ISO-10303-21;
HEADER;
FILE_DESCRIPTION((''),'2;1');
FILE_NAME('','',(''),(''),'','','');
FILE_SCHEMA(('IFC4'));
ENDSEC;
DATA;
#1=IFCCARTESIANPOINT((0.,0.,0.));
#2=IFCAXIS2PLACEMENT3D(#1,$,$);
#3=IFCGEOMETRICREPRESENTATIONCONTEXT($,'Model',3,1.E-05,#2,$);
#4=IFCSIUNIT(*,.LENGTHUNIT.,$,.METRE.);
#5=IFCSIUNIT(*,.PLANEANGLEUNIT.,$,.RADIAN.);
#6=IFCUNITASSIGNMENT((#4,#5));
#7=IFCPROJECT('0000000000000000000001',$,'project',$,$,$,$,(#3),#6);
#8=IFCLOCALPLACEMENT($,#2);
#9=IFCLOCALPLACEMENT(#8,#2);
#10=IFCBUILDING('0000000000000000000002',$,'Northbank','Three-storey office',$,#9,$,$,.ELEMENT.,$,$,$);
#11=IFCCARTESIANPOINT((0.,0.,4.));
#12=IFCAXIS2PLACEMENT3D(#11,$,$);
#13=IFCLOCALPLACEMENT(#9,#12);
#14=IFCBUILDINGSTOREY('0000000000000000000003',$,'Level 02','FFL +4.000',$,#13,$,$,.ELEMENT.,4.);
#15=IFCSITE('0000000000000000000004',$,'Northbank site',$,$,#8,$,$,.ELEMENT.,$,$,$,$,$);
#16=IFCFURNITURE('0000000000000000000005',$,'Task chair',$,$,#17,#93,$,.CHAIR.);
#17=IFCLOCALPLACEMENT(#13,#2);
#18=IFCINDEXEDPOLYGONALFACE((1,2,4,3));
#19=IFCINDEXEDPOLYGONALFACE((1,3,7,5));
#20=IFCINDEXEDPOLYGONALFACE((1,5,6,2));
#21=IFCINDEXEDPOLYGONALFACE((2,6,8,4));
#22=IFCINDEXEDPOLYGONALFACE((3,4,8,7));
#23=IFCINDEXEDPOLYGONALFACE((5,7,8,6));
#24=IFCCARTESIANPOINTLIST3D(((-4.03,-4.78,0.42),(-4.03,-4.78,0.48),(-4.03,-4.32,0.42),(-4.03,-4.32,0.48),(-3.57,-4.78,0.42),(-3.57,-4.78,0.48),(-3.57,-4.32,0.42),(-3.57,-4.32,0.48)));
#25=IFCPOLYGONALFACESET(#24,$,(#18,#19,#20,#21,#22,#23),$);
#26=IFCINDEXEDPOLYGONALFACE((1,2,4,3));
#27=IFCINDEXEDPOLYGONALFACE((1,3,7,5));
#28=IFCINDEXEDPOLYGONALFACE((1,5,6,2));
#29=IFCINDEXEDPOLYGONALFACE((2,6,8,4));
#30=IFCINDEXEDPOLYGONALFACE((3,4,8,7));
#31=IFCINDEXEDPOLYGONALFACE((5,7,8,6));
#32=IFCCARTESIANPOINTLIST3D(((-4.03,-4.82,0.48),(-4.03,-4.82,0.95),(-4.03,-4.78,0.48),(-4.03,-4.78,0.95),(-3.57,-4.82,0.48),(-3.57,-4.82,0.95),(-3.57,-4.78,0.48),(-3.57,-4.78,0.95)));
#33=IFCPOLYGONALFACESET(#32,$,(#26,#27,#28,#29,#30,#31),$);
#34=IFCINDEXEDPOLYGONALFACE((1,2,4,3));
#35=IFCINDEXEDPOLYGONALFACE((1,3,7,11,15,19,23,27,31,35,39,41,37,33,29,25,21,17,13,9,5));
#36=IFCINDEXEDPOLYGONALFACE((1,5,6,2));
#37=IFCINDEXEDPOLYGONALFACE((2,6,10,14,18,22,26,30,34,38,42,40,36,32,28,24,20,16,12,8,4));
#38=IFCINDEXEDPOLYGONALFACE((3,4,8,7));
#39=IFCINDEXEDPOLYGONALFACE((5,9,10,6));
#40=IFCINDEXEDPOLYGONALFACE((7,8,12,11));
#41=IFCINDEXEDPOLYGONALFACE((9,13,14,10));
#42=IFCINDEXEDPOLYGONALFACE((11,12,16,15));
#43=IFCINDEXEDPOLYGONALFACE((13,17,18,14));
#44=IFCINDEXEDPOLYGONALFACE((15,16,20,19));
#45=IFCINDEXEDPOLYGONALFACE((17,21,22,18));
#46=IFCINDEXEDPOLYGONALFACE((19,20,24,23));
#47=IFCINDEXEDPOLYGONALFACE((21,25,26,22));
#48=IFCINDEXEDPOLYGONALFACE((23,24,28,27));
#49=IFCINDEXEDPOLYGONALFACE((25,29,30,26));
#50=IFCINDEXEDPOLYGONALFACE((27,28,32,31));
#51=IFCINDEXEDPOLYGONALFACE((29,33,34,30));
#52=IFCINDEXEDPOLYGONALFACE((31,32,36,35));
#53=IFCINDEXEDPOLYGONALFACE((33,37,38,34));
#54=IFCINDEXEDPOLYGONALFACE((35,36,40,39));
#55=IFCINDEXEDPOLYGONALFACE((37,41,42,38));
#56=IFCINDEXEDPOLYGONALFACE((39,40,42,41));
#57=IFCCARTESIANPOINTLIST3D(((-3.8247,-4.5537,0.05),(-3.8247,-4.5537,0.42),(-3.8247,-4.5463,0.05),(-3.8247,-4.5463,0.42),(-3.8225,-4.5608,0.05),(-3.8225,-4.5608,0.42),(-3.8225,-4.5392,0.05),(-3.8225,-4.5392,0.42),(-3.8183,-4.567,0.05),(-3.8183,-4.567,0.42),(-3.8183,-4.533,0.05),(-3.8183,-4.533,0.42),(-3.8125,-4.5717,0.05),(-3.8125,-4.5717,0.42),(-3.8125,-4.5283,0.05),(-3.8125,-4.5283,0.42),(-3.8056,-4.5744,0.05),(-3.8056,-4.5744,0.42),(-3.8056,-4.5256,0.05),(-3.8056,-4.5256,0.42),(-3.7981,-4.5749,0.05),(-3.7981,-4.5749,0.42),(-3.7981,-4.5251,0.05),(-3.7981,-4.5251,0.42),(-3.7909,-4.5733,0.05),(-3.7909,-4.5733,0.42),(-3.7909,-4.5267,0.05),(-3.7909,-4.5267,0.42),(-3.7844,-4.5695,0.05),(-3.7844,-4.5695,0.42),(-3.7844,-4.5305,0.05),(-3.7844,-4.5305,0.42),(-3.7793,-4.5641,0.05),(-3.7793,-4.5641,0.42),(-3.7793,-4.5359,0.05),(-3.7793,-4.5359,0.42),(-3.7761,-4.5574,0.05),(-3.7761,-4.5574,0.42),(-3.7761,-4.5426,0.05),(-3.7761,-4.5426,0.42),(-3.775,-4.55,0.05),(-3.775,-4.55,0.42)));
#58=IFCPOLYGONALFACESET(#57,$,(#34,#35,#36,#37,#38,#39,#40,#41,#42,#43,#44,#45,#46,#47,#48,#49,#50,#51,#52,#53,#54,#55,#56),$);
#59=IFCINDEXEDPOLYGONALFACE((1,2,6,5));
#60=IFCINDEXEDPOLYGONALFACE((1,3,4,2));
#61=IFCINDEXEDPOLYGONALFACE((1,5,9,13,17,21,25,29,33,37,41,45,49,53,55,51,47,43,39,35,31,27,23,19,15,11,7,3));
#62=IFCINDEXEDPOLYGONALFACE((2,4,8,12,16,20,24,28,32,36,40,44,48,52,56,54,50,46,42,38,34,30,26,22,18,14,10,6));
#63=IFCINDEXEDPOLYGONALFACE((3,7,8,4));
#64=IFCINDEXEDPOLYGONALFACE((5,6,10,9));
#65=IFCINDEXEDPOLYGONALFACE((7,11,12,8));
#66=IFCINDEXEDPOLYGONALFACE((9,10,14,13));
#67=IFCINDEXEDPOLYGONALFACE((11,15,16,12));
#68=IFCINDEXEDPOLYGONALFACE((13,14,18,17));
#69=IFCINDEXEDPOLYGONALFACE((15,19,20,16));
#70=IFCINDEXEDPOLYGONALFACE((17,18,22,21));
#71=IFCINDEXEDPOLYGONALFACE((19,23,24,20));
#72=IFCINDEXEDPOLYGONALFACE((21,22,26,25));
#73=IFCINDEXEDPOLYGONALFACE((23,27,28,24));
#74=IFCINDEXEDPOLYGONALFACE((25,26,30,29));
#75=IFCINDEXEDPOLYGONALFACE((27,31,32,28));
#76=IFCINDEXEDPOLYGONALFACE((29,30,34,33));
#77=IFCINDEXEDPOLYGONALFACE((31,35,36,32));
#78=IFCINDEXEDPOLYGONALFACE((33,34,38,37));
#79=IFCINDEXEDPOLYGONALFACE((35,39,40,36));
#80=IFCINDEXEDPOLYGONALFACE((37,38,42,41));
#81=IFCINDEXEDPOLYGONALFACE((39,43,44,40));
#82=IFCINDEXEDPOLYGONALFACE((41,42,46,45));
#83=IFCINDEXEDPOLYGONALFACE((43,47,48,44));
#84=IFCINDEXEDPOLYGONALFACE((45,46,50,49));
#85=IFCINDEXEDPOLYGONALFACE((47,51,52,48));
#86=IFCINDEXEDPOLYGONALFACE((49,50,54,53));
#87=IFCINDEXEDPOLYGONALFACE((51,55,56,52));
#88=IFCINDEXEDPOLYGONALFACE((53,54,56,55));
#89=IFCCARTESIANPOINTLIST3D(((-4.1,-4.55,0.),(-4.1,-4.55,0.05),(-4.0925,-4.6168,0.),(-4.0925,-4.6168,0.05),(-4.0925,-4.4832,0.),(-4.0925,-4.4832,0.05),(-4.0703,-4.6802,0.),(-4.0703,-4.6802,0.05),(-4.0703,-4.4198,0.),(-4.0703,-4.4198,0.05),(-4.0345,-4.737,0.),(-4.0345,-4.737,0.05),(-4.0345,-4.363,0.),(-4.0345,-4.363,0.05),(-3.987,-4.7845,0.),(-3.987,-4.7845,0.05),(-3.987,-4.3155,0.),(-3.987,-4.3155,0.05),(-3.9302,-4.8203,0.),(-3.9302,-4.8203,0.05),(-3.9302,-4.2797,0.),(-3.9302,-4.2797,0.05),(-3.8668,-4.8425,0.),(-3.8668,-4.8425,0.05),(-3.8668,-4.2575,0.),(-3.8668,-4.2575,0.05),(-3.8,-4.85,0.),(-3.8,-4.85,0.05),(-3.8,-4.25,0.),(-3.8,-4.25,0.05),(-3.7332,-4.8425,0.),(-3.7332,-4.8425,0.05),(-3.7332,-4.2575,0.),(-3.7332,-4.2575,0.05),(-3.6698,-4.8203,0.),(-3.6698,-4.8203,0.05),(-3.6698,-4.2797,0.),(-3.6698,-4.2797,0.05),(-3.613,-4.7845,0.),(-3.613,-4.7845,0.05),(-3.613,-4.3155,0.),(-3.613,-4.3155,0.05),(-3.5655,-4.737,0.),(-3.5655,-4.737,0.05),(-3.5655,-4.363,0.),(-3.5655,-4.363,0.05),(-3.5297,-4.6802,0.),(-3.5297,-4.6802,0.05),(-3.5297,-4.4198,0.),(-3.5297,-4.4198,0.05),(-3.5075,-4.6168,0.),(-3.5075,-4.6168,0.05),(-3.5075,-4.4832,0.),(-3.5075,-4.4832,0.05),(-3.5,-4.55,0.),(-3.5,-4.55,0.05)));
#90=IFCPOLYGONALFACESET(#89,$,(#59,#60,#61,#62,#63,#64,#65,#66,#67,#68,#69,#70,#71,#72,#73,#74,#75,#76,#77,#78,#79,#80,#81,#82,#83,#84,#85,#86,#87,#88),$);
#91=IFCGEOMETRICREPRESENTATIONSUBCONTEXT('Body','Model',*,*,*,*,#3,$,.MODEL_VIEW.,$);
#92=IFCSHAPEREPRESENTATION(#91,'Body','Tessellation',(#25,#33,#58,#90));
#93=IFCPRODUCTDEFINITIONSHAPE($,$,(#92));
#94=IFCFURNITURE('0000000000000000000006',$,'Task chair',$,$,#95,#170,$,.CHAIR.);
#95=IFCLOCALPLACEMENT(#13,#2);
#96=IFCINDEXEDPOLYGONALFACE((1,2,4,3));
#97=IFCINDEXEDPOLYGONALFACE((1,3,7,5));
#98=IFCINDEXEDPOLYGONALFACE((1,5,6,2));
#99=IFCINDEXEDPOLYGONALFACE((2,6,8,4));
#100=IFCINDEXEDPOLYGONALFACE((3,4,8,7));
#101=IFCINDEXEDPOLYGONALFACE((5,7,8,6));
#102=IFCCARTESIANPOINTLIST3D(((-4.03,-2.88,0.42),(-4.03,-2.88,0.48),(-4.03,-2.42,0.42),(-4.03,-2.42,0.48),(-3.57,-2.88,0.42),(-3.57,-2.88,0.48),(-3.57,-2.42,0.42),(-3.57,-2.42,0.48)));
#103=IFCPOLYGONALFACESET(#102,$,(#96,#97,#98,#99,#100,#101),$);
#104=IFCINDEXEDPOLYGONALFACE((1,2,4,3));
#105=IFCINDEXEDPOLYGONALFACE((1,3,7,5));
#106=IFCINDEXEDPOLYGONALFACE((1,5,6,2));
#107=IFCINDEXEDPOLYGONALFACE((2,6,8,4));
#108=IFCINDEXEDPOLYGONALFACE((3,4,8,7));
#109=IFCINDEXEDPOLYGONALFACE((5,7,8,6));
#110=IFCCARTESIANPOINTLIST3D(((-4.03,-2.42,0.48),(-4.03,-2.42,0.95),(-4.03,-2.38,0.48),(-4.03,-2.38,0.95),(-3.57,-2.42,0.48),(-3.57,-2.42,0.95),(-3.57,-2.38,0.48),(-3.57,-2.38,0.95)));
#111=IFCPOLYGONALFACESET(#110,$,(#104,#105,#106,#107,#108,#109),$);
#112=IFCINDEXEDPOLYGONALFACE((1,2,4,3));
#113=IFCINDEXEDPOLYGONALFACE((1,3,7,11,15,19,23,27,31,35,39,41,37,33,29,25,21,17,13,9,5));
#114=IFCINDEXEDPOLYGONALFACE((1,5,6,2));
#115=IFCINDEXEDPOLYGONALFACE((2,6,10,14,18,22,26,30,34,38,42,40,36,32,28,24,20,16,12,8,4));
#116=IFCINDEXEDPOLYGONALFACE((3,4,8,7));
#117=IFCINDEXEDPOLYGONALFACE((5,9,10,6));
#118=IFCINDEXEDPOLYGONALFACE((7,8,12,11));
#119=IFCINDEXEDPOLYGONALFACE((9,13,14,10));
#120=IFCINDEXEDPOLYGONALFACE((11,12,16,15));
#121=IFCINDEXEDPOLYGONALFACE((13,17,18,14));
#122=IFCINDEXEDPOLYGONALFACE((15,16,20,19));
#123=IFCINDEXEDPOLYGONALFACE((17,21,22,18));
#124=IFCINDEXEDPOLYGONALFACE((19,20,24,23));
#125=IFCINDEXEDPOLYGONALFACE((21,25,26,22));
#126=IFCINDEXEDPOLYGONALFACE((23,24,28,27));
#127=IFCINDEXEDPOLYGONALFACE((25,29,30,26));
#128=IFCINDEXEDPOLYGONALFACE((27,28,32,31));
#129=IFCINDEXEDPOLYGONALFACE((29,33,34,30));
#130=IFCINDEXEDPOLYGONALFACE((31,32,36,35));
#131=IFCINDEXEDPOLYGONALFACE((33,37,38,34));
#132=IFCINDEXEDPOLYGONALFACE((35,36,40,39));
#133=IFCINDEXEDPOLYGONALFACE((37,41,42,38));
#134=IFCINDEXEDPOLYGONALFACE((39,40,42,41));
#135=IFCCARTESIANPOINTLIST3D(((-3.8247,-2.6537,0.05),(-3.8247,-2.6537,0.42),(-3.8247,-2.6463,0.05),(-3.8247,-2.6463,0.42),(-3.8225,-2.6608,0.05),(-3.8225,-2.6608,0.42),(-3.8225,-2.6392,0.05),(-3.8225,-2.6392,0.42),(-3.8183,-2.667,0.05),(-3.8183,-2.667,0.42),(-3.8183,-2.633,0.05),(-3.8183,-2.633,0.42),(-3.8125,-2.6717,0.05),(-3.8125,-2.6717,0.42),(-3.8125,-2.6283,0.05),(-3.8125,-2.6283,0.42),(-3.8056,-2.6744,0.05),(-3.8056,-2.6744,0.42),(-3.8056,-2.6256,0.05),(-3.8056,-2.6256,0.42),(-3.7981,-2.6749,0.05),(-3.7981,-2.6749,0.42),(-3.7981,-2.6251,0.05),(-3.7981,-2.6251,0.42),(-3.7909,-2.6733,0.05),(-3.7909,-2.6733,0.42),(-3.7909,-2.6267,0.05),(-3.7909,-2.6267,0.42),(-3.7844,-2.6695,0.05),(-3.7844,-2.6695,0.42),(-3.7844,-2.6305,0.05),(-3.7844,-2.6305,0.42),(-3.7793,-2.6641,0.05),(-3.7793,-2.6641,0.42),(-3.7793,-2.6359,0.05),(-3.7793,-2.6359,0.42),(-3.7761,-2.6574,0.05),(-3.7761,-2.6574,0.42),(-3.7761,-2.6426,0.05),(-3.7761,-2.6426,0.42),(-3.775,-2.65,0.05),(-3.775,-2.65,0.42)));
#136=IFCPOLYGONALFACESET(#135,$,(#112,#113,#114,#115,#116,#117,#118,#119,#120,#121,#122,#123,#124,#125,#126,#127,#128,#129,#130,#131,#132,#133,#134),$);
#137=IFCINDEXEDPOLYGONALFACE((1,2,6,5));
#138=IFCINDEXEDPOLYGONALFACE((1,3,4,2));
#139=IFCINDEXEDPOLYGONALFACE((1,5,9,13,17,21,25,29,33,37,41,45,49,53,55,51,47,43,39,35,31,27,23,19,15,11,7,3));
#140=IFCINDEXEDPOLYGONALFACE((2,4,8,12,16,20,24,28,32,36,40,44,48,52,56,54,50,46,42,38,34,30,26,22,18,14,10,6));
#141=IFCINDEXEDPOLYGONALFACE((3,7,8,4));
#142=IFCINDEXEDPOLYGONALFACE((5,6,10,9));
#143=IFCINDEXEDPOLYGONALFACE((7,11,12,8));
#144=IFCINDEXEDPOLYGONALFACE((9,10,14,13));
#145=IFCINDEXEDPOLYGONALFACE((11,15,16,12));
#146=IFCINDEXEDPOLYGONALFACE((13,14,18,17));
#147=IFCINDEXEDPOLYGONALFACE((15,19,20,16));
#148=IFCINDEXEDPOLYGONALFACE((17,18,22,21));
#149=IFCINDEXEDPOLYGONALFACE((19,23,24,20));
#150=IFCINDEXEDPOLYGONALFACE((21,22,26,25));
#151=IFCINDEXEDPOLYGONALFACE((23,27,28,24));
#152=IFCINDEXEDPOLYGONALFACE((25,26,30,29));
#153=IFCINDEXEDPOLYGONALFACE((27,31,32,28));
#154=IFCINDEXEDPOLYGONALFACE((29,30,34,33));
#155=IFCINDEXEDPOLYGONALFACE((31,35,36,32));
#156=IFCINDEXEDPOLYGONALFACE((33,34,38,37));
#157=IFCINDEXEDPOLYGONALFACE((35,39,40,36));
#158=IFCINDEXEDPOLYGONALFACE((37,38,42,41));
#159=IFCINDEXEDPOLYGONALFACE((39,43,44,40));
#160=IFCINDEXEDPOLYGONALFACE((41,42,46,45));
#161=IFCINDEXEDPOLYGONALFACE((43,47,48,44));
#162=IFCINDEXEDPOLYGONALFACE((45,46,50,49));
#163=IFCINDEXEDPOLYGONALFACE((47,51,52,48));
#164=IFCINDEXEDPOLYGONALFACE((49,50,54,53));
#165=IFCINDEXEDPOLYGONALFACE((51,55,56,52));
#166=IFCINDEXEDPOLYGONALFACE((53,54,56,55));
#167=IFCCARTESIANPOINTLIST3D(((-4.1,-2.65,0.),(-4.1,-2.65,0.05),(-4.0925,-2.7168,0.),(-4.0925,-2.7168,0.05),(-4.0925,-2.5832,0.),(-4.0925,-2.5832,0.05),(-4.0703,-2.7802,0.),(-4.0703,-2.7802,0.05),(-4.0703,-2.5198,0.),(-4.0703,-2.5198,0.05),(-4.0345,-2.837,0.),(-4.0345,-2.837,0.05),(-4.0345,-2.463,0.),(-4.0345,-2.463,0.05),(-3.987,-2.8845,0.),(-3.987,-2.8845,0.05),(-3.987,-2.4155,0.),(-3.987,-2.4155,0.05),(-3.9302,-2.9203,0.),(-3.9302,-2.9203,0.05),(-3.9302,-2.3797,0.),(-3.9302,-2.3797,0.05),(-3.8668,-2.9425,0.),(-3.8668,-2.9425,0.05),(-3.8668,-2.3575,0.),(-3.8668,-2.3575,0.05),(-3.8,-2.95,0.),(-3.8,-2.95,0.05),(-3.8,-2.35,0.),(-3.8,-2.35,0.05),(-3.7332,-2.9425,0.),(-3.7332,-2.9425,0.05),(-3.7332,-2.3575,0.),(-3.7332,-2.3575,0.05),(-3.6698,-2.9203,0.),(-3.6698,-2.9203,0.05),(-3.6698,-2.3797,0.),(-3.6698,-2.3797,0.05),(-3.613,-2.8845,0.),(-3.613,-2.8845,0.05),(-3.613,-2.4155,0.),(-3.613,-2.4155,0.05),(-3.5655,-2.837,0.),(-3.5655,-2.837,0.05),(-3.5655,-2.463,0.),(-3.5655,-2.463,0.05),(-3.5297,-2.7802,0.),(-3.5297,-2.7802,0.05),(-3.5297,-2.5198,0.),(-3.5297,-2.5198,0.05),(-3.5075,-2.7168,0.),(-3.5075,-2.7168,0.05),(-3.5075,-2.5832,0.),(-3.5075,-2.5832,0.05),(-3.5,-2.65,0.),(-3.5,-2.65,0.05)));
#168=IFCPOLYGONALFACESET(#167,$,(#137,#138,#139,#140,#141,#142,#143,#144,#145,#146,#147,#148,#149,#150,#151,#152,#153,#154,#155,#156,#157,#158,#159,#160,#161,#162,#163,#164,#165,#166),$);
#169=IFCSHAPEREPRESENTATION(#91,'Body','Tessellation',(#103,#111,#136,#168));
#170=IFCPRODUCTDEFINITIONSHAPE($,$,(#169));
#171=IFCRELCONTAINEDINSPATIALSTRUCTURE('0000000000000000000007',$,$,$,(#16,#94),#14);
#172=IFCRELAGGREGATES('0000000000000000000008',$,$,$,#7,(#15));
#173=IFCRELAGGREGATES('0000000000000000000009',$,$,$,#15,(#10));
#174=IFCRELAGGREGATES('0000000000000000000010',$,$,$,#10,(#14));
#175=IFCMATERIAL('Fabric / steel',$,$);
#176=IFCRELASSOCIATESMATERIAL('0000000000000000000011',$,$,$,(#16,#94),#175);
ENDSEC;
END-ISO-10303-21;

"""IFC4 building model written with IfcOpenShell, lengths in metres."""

from ifc_helpers import new_model, si_unit, frame, origin, place, context, subcontext, project, spatial, rectangle, circle, extrude, material, element, save


model = new_model("IFC4")

# Units and contexts
model_context = context("Model", 3, precision=1e-05, world=origin())
body_context = subcontext(model_context, "Body", "Model", "MODEL_VIEW")
ifc_project = project(units=[si_unit("LENGTHUNIT", "METRE"), si_unit("PLANEANGLEUNIT", "RADIAN")], contexts=[model_context])

# Site, building, storey
site_placement = place(None, origin())
site = spatial("IfcSite", under=ifc_project, at=site_placement, Name="Northbank site", CompositionType="ELEMENT")
building_placement = place(site_placement, origin())
building = spatial("IfcBuilding", under=site, at=building_placement, Name="Northbank", Description="Three-storey office", CompositionType="ELEMENT")
storey_placement = place(building_placement, frame((0.0, 0.0, 4.0)))
storey = spatial("IfcBuildingStorey", under=building, at=storey_placement, Name="Level 02", Description="FFL +4.000", CompositionType="ELEMENT", Elevation=4.0)

# Furniture
ifc_material_1 = material(Name="Fabric / steel")
furniture_1_placement = place(storey_placement, frame((0.0, 0.0, -4.0)))
element("IfcFurniture", 1, at=furniture_1_placement, inside=storey, material=ifc_material_1, Name="Task chair", PredefinedType="CHAIR", context=body_context, shape_type="SweptSolid", body=[
    extrude(rectangle(XDim=0.46, YDim=0.46), frame((-3.8, -4.55, 4.42)), (0.0, 0.0, 1.0), 0.06),
    extrude(rectangle(XDim=0.46, YDim=0.04), frame((-3.8, -4.8, 4.48)), (0.0, 0.0, 1.0), 0.47),
    extrude(circle(Radius=0.025), frame((-3.8, -4.55, 4.05), z_axis=(0.0, 0.0, 1.0), x_axis=(1.0, 0.0, 0.0)), (0.0, 0.0, 1.0), 0.37),
    extrude(circle(Radius=0.3), frame((-3.8, -4.55, 4.0), z_axis=(0.0, 0.0, 1.0), x_axis=(1.0, 0.0, 0.0)), (0.0, 0.0, 1.0), 0.05),
])
furniture_2_placement = place(storey_placement, frame((0.0, 0.0, -4.0)))
element("IfcFurniture", 2, at=furniture_2_placement, inside=storey, material=ifc_material_1, Name="Task chair", PredefinedType="CHAIR", context=body_context, shape_type="SweptSolid", body=[
    extrude(rectangle(XDim=0.46, YDim=0.46), frame((-3.8, -2.65, 4.42)), (0.0, 0.0, 1.0), 0.06),
    extrude(rectangle(XDim=0.46, YDim=0.04), frame((-3.8, -2.4, 4.48)), (0.0, 0.0, 1.0), 0.47),
    extrude(circle(Radius=0.025), frame((-3.8, -2.65, 4.05), z_axis=(0.0, 0.0, 1.0), x_axis=(1.0, 0.0, 0.0)), (0.0, 0.0, 1.0), 0.37),
    extrude(circle(Radius=0.3), frame((-3.8, -2.65, 4.0), z_axis=(0.0, 0.0, 1.0), x_axis=(1.0, 0.0, 0.0)), (0.0, 0.0, 1.0), 0.05),
])

save(model, "model.ifc")
